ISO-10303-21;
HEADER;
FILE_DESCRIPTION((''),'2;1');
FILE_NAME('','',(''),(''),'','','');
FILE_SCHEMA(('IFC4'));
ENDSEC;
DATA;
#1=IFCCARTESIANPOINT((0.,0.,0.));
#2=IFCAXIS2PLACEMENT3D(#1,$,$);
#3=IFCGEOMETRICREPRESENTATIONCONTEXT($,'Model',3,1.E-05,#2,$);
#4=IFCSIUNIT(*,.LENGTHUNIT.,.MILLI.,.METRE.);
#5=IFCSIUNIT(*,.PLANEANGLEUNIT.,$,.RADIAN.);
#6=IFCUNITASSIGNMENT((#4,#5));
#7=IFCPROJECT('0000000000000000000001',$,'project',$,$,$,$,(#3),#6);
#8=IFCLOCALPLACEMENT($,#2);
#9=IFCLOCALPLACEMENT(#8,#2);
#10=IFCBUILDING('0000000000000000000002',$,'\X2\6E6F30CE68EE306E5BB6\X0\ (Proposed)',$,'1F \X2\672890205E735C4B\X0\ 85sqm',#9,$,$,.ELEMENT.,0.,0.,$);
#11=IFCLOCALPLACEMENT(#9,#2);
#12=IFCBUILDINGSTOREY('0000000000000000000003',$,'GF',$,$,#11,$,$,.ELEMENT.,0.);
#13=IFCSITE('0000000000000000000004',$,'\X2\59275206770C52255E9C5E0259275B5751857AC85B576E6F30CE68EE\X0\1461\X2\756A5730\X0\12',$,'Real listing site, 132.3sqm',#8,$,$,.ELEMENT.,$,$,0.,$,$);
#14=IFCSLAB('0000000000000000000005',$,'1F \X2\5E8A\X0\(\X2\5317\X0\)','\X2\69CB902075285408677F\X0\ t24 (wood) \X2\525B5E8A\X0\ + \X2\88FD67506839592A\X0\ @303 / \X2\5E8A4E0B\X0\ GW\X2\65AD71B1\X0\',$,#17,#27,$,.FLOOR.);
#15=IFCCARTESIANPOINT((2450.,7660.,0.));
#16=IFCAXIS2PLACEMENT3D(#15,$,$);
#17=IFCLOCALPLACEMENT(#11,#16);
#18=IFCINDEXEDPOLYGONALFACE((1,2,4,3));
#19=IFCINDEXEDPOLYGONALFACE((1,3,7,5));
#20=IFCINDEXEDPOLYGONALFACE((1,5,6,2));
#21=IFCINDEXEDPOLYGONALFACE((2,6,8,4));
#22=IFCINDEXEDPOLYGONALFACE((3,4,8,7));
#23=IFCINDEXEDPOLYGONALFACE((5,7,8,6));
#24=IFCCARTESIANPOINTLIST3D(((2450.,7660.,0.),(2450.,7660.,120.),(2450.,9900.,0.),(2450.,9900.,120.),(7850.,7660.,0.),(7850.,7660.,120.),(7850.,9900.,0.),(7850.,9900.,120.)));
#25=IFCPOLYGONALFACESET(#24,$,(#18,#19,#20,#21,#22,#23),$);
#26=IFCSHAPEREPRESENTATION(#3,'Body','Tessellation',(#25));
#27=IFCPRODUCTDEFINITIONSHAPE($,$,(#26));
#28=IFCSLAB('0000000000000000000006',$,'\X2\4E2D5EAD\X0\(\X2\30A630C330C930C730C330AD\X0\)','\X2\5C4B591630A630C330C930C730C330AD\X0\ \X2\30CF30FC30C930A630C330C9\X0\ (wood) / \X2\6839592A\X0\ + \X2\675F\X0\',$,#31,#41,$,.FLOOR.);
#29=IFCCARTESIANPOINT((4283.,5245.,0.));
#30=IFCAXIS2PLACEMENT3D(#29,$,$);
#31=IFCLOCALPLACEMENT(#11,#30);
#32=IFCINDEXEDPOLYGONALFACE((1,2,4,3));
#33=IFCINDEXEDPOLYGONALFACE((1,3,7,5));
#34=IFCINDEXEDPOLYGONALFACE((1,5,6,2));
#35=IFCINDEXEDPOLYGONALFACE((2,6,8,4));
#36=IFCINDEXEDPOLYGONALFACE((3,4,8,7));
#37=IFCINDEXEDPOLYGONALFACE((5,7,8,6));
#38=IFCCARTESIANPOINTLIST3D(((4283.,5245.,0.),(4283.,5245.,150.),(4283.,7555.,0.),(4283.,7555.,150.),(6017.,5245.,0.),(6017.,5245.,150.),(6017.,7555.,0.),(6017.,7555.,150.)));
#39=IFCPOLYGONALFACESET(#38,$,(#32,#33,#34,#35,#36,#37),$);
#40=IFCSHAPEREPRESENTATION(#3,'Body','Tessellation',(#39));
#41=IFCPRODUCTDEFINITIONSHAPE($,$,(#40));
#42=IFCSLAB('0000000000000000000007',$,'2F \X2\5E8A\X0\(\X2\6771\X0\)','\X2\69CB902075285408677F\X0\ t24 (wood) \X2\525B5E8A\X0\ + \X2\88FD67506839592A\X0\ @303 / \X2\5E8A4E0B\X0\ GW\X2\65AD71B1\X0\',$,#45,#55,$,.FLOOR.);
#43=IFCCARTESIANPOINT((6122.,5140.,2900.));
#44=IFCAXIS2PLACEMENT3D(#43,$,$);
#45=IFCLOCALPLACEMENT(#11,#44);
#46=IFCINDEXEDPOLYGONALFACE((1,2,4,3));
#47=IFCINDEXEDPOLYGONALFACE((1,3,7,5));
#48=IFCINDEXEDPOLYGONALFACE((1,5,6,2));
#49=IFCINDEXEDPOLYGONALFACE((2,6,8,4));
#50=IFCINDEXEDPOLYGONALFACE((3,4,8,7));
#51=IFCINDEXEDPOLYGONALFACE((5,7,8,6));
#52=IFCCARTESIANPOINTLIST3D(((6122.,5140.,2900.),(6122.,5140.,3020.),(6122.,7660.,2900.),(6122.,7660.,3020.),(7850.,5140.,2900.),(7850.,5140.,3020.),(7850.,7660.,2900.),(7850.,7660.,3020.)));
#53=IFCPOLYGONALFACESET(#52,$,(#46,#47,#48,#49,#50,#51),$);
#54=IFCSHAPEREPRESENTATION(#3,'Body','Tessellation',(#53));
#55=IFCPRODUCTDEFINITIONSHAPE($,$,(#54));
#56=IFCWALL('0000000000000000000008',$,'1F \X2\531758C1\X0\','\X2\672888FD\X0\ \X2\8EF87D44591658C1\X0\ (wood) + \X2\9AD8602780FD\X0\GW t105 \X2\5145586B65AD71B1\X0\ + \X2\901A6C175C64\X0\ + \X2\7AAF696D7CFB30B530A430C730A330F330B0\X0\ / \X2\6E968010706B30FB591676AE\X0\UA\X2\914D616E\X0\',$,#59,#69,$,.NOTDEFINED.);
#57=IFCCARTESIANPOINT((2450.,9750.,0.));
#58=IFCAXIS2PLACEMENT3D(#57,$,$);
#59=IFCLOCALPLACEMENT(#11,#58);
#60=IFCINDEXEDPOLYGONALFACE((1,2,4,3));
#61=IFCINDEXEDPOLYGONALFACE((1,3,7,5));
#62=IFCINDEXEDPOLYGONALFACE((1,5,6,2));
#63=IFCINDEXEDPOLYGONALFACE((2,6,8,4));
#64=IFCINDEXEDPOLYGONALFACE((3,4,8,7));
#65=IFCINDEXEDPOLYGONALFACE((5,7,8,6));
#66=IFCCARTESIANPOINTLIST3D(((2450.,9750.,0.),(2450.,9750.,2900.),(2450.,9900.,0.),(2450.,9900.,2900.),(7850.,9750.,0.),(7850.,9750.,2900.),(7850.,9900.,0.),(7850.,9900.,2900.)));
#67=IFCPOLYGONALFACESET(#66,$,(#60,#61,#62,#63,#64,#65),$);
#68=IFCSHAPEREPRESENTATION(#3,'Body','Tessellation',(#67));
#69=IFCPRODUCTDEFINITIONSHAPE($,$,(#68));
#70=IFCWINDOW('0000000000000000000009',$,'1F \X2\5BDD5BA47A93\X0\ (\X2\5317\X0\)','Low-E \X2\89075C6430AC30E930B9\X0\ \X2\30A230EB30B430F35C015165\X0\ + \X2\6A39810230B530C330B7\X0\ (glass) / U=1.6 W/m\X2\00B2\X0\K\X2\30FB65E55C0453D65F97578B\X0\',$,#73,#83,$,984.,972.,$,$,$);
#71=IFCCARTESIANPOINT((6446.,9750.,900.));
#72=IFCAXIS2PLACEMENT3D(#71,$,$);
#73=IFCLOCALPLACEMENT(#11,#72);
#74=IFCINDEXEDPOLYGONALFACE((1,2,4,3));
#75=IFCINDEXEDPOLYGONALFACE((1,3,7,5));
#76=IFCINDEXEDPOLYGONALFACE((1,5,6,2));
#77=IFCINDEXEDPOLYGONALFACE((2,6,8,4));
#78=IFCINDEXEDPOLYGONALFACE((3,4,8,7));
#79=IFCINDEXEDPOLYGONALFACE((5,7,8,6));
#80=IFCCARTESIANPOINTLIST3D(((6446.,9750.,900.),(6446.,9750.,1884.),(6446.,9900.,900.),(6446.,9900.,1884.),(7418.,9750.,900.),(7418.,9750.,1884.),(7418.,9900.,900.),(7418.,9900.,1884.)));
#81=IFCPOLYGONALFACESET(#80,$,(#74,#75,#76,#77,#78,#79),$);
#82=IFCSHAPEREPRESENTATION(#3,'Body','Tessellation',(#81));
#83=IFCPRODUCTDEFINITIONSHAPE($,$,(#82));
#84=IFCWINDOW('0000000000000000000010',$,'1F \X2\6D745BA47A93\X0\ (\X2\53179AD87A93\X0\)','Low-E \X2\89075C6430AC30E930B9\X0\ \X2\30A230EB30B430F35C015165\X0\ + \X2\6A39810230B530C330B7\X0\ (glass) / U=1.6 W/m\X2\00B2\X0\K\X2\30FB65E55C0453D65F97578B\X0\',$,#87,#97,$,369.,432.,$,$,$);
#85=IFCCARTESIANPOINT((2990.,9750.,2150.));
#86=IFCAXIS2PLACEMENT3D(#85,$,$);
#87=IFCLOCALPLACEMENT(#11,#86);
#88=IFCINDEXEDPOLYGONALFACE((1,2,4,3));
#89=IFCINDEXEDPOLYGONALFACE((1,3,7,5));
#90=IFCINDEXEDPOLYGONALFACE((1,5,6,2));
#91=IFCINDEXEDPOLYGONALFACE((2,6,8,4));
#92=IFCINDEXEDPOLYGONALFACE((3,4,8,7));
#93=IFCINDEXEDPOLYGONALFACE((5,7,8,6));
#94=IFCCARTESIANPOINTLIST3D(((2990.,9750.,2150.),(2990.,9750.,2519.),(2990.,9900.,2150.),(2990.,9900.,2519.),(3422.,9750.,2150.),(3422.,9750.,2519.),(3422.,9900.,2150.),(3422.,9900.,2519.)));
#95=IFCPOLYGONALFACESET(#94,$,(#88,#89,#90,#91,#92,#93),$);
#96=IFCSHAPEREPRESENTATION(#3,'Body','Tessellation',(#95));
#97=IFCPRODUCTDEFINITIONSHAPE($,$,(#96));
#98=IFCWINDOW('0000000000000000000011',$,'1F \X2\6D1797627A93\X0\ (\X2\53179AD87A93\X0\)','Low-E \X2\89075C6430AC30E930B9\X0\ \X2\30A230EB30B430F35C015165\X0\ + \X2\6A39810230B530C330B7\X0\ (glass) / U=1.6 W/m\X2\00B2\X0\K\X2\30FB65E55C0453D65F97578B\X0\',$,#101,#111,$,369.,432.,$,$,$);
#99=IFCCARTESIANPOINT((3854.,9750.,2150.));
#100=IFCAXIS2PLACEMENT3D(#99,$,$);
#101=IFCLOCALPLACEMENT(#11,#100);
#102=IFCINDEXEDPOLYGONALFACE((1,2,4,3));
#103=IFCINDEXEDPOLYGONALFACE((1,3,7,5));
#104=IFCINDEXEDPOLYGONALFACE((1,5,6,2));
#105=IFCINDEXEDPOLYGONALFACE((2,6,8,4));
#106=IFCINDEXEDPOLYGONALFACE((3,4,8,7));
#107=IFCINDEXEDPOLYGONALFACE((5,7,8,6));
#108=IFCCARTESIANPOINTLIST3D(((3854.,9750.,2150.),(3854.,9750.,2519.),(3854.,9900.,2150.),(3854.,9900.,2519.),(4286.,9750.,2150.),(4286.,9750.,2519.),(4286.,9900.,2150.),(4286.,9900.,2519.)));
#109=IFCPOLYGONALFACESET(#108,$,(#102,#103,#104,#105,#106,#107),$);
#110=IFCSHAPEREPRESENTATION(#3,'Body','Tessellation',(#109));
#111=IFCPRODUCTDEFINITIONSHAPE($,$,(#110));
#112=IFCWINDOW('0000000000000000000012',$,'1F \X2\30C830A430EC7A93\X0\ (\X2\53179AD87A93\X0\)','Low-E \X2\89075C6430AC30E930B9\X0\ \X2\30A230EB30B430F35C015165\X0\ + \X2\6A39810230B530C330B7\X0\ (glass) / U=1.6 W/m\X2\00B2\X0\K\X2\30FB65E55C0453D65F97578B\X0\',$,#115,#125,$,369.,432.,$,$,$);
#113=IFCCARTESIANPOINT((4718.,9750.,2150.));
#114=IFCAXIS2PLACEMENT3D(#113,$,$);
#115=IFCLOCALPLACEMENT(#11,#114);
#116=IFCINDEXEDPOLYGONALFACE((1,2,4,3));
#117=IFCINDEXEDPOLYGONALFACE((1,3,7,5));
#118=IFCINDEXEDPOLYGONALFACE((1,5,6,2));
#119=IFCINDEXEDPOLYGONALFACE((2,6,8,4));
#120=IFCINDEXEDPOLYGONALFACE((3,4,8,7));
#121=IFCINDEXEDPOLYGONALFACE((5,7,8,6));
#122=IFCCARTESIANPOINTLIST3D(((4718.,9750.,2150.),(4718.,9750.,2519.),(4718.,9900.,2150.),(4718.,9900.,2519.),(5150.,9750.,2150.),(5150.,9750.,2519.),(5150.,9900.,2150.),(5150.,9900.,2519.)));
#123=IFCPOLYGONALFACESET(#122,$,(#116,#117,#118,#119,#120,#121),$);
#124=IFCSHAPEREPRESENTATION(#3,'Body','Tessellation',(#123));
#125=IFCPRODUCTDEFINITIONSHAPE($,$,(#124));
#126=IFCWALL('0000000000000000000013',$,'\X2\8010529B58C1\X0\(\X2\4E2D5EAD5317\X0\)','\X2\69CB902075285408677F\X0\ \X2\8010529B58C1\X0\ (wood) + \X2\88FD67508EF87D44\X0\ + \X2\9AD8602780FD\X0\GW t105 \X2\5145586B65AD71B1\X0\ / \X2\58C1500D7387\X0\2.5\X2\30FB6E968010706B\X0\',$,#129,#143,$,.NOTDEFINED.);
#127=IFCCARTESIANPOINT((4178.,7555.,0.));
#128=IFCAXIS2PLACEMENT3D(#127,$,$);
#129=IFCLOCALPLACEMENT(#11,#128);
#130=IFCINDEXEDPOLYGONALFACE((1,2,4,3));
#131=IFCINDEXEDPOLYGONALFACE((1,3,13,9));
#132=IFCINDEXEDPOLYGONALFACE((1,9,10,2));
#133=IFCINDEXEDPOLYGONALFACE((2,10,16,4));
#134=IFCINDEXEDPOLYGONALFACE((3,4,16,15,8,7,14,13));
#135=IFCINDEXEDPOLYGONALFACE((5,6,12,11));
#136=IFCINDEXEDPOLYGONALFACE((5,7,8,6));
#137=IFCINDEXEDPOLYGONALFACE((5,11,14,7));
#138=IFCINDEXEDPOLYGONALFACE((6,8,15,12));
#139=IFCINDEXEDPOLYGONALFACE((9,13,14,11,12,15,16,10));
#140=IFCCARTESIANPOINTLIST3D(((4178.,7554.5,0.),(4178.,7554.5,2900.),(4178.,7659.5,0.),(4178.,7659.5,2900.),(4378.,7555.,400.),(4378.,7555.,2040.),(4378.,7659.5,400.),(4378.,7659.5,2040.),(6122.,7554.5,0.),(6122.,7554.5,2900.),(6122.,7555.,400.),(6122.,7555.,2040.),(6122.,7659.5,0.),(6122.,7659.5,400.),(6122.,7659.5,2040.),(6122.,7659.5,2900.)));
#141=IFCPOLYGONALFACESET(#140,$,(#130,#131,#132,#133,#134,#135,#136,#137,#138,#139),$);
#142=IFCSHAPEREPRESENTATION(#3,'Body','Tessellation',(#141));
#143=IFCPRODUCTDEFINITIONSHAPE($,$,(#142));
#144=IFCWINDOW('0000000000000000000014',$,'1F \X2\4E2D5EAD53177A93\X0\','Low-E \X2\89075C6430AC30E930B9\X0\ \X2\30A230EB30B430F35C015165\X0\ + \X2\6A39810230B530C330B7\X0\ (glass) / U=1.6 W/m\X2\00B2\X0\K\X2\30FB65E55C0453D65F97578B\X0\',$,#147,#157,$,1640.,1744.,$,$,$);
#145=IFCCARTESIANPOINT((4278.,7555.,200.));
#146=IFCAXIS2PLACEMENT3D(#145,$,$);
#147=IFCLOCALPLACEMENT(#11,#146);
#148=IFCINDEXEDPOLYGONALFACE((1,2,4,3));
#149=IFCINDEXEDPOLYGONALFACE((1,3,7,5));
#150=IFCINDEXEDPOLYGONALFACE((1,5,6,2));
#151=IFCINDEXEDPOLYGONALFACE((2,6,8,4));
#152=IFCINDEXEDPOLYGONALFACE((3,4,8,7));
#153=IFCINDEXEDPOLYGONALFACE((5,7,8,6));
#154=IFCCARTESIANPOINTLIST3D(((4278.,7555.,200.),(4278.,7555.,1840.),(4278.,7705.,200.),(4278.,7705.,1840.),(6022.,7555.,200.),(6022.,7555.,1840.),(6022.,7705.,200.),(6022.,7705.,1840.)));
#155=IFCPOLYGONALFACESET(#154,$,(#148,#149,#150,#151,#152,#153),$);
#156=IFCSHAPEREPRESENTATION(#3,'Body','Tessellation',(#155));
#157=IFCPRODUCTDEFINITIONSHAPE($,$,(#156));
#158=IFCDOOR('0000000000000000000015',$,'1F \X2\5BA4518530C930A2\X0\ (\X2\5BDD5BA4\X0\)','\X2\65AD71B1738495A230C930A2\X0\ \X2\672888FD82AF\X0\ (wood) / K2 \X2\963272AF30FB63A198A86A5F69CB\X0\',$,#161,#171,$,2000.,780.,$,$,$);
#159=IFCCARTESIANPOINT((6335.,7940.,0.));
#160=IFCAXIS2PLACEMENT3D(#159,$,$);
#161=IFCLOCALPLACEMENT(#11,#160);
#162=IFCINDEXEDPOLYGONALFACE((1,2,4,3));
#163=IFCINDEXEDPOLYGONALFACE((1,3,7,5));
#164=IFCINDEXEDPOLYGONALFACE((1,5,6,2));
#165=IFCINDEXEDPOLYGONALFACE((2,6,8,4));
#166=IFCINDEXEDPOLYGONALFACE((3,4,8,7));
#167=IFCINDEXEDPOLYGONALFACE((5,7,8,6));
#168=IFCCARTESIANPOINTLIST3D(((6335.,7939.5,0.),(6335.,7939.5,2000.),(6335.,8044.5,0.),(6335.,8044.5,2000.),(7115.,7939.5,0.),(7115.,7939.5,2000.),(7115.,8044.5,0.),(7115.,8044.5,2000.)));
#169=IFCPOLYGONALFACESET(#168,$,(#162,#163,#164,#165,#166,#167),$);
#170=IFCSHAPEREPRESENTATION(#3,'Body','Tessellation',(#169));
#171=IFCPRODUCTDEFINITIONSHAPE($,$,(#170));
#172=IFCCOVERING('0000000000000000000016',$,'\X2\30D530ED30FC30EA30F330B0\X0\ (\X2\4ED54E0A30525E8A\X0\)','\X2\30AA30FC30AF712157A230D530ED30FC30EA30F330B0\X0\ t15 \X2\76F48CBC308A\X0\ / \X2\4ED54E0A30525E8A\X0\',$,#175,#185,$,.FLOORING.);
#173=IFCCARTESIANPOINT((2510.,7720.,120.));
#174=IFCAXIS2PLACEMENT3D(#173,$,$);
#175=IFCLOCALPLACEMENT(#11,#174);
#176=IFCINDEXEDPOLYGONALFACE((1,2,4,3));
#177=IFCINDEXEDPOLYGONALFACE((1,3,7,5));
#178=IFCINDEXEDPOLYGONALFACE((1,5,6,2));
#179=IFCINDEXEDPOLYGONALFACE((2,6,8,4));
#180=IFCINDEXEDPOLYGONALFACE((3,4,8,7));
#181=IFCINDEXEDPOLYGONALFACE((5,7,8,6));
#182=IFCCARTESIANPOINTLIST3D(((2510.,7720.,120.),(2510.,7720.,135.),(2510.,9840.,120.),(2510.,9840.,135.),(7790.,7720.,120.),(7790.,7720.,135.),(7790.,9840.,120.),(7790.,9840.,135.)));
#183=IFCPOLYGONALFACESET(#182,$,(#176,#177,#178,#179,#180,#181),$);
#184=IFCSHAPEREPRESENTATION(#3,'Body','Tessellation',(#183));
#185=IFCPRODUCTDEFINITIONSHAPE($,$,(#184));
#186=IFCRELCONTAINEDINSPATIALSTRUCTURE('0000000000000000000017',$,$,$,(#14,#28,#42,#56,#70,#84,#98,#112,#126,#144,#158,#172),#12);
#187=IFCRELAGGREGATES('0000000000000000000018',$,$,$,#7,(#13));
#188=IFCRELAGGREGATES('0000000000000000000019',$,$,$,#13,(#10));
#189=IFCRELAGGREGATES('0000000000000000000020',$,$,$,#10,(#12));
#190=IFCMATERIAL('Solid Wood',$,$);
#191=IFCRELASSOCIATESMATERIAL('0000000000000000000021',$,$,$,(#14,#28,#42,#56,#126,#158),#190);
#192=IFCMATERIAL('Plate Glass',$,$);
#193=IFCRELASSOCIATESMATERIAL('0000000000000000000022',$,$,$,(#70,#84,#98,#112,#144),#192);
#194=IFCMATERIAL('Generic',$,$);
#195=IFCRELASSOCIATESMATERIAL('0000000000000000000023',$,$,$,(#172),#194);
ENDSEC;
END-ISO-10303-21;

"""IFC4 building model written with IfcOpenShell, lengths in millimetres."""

from ifc_helpers import new_model, si_unit, frame, frame_2d, origin, place, context, project, spatial, rectangle, extrude, material, element, fill, save


model = new_model("IFC4")

# Units and contexts
model_context = context("Model", 3, precision=1e-05, world=origin())
ifc_project = project(units=[si_unit("LENGTHUNIT", "METRE", prefix="MILLI"), si_unit("PLANEANGLEUNIT", "RADIAN")], contexts=[model_context])

# Site, building, storey
site_placement = place(None, origin())
site = spatial("IfcSite", under=ifc_project, at=site_placement, Name="大分県別府市大字内竈字湯ノ森1461番地12", ObjectType="Real listing site, 132.3sqm", CompositionType="ELEMENT", RefElevation=0.0)
building_placement = place(site_placement, origin())
building = spatial("IfcBuilding", under=site, at=building_placement, Name="湯ノ森の家 (Proposed)", ObjectType="1F 木造平屋 85sqm", CompositionType="ELEMENT", ElevationOfRefHeight=0.0, ElevationOfTerrain=0.0)
storey_placement = place(building_placement, origin())
storey = spatial("IfcBuildingStorey", under=building, at=storey_placement, Name="GF", CompositionType="ELEMENT", Elevation=0.0)

# Slabs
ifc_material_1 = material(Name="Solid Wood")
slab_1_placement = place(storey_placement, frame((2450.0, 7660.0, 0.0)))
element("IfcSlab", 1, at=slab_1_placement, inside=storey, material=ifc_material_1, Name="1F 床(北)", Description="構造用合板 t24 (wood) 剛床 + 製材根太 @303 / 床下 GW断熱", PredefinedType="FLOOR", context=model_context, shape_type="SweptSolid", body=[
    extrude(rectangle(XDim=5400.0, YDim=2240.0, at=frame_2d((2700.0, 1120.0))), frame((2450.0, 7660.0, 0.0)), (0.0, 0.0, 1.0), 120.0),
])
slab_2_placement = place(storey_placement, frame((4283.0, 5245.0, 0.0)))
element("IfcSlab", 2, at=slab_2_placement, inside=storey, material=ifc_material_1, Name="中庭(ウッドデッキ)", Description="屋外ウッドデッキ ハードウッド (wood) / 根太 + 束", PredefinedType="FLOOR", context=model_context, shape_type="SweptSolid", body=[
    extrude(rectangle(XDim=1734.0, YDim=2310.0, at=frame_2d((867.0, 1155.0))), frame((4283.0, 5245.0, 0.0)), (0.0, 0.0, 1.0), 150.0),
])
slab_3_placement = place(storey_placement, frame((6122.0, 5140.0, 2900.0)))
element("IfcSlab", 3, at=slab_3_placement, inside=storey, material=ifc_material_1, Name="2F 床(東)", Description="構造用合板 t24 (wood) 剛床 + 製材根太 @303 / 床下 GW断熱", PredefinedType="FLOOR", context=model_context, shape_type="SweptSolid", body=[
    extrude(rectangle(XDim=1728.0, YDim=2520.0, at=frame_2d((864.0, 1260.0))), frame((6122.0, 5140.0, 2900.0)), (0.0, 0.0, 1.0), 120.0),
])

# Wall, openings, windows
wall_1_placement = place(storey_placement, frame((2450.0, 9750.0, 0.0)))
wall_1 = element("IfcWall", 4, at=wall_1_placement, inside=storey, material=ifc_material_1, Name="1F 北壁", Description="木製 軸組外壁 (wood) + 高性能GW t105 充填断熱 + 通気層 + 窯業系サイディング / 準耐火・外皮UA配慮", PredefinedType="NOTDEFINED", context=model_context, shape_type="SweptSolid", body=[
    extrude(rectangle(XDim=5400.0, YDim=150.0, at=frame_2d((2700.0, 75.0))), frame((2450.0, 9750.0, 0.0)), (0.0, 0.0, 1.0), 2900.0),
])
opening_1_placement = place(storey_placement, frame((6446.0, 9750.0, 900.0)))
opening_1 = element("IfcOpeningElement", 5, at=opening_1_placement, cuts=wall_1, PredefinedType="NOTDEFINED", context=model_context, shape_type="SweptSolid", body=[
    extrude(rectangle(XDim=972.0, YDim=150.0, at=frame_2d((486.0, 75.0))), frame((6446.0, 9750.0, 900.0)), (0.0, 0.0, 1.0), 984.0),
])
opening_2_placement = place(storey_placement, frame((2990.0, 9750.0, 2150.0)))
opening_2 = element("IfcOpeningElement", 6, at=opening_2_placement, cuts=wall_1, PredefinedType="NOTDEFINED", context=model_context, shape_type="SweptSolid", body=[
    extrude(rectangle(XDim=432.0, YDim=150.0, at=frame_2d((216.0, 75.0))), frame((2990.0, 9750.0, 2150.0)), (0.0, 0.0, 1.0), 369.0),
])
opening_3_placement = place(storey_placement, frame((3854.0, 9750.0, 2150.0)))
opening_3 = element("IfcOpeningElement", 7, at=opening_3_placement, cuts=wall_1, PredefinedType="NOTDEFINED", context=model_context, shape_type="SweptSolid", body=[
    extrude(rectangle(XDim=432.0, YDim=150.0, at=frame_2d((216.0, 75.0))), frame((3854.0, 9750.0, 2150.0)), (0.0, 0.0, 1.0), 369.0),
])
opening_4_placement = place(storey_placement, frame((4718.0, 9750.0, 2150.0)))
opening_4 = element("IfcOpeningElement", 8, at=opening_4_placement, cuts=wall_1, PredefinedType="NOTDEFINED", context=model_context, shape_type="SweptSolid", body=[
    extrude(rectangle(XDim=432.0, YDim=150.0, at=frame_2d((216.0, 75.0))), frame((4718.0, 9750.0, 2150.0)), (0.0, 0.0, 1.0), 369.0),
])
ifc_material_2 = material(Name="Plate Glass")
window_1_placement = place(storey_placement, frame((6446.0, 9750.0, 900.0)))
window_1 = element("IfcWindow", 9, at=window_1_placement, inside=storey, material=ifc_material_2, Name="1F 寝室窓 (北)", Description="Low-E 複層ガラス アルゴン封入 + 樹脂サッシ (glass) / U=1.6 W/m²K・日射取得型", OverallHeight=984.0, OverallWidth=972.0, context=model_context, shape_type="SweptSolid", body=[
    extrude(rectangle(XDim=972.0, YDim=150.0, at=frame_2d((486.0, 75.0))), frame((6446.0, 9750.0, 900.0)), (0.0, 0.0, 1.0), 984.0),
])
fill(opening_1, window_1)
window_2_placement = place(storey_placement, frame((2990.0, 9750.0, 2150.0)))
window_2 = element("IfcWindow", 10, at=window_2_placement, inside=storey, material=ifc_material_2, Name="1F 浴室窓 (北高窓)", Description="Low-E 複層ガラス アルゴン封入 + 樹脂サッシ (glass) / U=1.6 W/m²K・日射取得型", OverallHeight=369.0, OverallWidth=432.0, context=model_context, shape_type="SweptSolid", body=[
    extrude(rectangle(XDim=432.0, YDim=150.0, at=frame_2d((216.0, 75.0))), frame((2990.0, 9750.0, 2150.0)), (0.0, 0.0, 1.0), 369.0),
])
fill(opening_2, window_2)
window_3_placement = place(storey_placement, frame((3854.0, 9750.0, 2150.0)))
window_3 = element("IfcWindow", 11, at=window_3_placement, inside=storey, material=ifc_material_2, Name="1F 洗面窓 (北高窓)", Description="Low-E 複層ガラス アルゴン封入 + 樹脂サッシ (glass) / U=1.6 W/m²K・日射取得型", OverallHeight=369.0, OverallWidth=432.0, context=model_context, shape_type="SweptSolid", body=[
    extrude(rectangle(XDim=432.0, YDim=150.0, at=frame_2d((216.0, 75.0))), frame((3854.0, 9750.0, 2150.0)), (0.0, 0.0, 1.0), 369.0),
])
fill(opening_3, window_3)
window_4_placement = place(storey_placement, frame((4718.0, 9750.0, 2150.0)))
window_4 = element("IfcWindow", 12, at=window_4_placement, inside=storey, material=ifc_material_2, Name="1F トイレ窓 (北高窓)", Description="Low-E 複層ガラス アルゴン封入 + 樹脂サッシ (glass) / U=1.6 W/m²K・日射取得型", OverallHeight=369.0, OverallWidth=432.0, context=model_context, shape_type="SweptSolid", body=[
    extrude(rectangle(XDim=432.0, YDim=150.0, at=frame_2d((216.0, 75.0))), frame((4718.0, 9750.0, 2150.0)), (0.0, 0.0, 1.0), 369.0),
])
fill(opening_4, window_4)

# Wall, opening, window
wall_2_placement = place(storey_placement, frame((4178.0, 7555.0, 0.0)))
wall_2 = element("IfcWall", 13, at=wall_2_placement, inside=storey, material=ifc_material_1, Name="耐力壁(中庭北)", Description="構造用合板 耐力壁 (wood) + 製材軸組 + 高性能GW t105 充填断熱 / 壁倍率2.5・準耐火", PredefinedType="NOTDEFINED", context=model_context, shape_type="SweptSolid", body=[
    extrude(rectangle(XDim=1944.0, YDim=105.0, at=frame_2d((972.0, 52.0))), frame((4178.0, 7555.0, 0.0)), (0.0, 0.0, 1.0), 2900.0),
])
opening_5_placement = place(storey_placement, frame((4278.0, 7555.0, 200.0)))
opening_5 = element("IfcOpeningElement", 14, at=opening_5_placement, cuts=wall_2, PredefinedType="NOTDEFINED", context=model_context, shape_type="SweptSolid", body=[
    extrude(rectangle(XDim=1744.0, YDim=150.0, at=frame_2d((872.0, 75.0))), frame((4278.0, 7555.0, 200.0)), (0.0, 0.0, 1.0), 1640.0),
])
window_5_placement = place(storey_placement, frame((4278.0, 7555.0, 200.0)))
window_5 = element("IfcWindow", 15, at=window_5_placement, inside=storey, material=ifc_material_2, Name="1F 中庭北窓", Description="Low-E 複層ガラス アルゴン封入 + 樹脂サッシ (glass) / U=1.6 W/m²K・日射取得型", OverallHeight=1640.0, OverallWidth=1744.0, context=model_context, shape_type="SweptSolid", body=[
    extrude(rectangle(XDim=1744.0, YDim=150.0, at=frame_2d((872.0, 75.0))), frame((4278.0, 7555.0, 200.0)), (0.0, 0.0, 1.0), 1640.0),
])
fill(opening_5, window_5)

# Door
door_1_placement = place(storey_placement, frame((6335.0, 7940.0, 0.0)))
element("IfcDoor", 16, at=door_1_placement, inside=storey, material=ifc_material_1, Name="1F 室内ドア (寝室)", Description="断熱玄関ドア 木製芯 (wood) / K2 防犯・採風機構", OverallHeight=2000.0, OverallWidth=780.0, context=model_context, shape_type="SweptSolid", body=[
    extrude(rectangle(XDim=780.0, YDim=105.0, at=frame_2d((390.0, 52.0))), frame((6335.0, 7940.0, 0.0)), (0.0, 0.0, 1.0), 2000.0),
])

# Covering
ifc_material_3 = material(Name="Generic")
covering_1_placement = place(storey_placement, frame((2510.0, 7720.0, 120.0)))
element("IfcCovering", 17, at=covering_1_placement, inside=storey, material=ifc_material_3, Name="フローリング (仕上げ床)", Description="オーク無垢フローリング t15 直貼り / 仕上げ床", PredefinedType="FLOORING", context=model_context, shape_type="SweptSolid", body=[
    extrude(rectangle(XDim=5280.0, YDim=2120.0, at=frame_2d((2640.0, 1060.0))), frame((2510.0, 7720.0, 120.0)), (0.0, 0.0, 1.0), 15.0),
])

save(model, "model.ifc")
